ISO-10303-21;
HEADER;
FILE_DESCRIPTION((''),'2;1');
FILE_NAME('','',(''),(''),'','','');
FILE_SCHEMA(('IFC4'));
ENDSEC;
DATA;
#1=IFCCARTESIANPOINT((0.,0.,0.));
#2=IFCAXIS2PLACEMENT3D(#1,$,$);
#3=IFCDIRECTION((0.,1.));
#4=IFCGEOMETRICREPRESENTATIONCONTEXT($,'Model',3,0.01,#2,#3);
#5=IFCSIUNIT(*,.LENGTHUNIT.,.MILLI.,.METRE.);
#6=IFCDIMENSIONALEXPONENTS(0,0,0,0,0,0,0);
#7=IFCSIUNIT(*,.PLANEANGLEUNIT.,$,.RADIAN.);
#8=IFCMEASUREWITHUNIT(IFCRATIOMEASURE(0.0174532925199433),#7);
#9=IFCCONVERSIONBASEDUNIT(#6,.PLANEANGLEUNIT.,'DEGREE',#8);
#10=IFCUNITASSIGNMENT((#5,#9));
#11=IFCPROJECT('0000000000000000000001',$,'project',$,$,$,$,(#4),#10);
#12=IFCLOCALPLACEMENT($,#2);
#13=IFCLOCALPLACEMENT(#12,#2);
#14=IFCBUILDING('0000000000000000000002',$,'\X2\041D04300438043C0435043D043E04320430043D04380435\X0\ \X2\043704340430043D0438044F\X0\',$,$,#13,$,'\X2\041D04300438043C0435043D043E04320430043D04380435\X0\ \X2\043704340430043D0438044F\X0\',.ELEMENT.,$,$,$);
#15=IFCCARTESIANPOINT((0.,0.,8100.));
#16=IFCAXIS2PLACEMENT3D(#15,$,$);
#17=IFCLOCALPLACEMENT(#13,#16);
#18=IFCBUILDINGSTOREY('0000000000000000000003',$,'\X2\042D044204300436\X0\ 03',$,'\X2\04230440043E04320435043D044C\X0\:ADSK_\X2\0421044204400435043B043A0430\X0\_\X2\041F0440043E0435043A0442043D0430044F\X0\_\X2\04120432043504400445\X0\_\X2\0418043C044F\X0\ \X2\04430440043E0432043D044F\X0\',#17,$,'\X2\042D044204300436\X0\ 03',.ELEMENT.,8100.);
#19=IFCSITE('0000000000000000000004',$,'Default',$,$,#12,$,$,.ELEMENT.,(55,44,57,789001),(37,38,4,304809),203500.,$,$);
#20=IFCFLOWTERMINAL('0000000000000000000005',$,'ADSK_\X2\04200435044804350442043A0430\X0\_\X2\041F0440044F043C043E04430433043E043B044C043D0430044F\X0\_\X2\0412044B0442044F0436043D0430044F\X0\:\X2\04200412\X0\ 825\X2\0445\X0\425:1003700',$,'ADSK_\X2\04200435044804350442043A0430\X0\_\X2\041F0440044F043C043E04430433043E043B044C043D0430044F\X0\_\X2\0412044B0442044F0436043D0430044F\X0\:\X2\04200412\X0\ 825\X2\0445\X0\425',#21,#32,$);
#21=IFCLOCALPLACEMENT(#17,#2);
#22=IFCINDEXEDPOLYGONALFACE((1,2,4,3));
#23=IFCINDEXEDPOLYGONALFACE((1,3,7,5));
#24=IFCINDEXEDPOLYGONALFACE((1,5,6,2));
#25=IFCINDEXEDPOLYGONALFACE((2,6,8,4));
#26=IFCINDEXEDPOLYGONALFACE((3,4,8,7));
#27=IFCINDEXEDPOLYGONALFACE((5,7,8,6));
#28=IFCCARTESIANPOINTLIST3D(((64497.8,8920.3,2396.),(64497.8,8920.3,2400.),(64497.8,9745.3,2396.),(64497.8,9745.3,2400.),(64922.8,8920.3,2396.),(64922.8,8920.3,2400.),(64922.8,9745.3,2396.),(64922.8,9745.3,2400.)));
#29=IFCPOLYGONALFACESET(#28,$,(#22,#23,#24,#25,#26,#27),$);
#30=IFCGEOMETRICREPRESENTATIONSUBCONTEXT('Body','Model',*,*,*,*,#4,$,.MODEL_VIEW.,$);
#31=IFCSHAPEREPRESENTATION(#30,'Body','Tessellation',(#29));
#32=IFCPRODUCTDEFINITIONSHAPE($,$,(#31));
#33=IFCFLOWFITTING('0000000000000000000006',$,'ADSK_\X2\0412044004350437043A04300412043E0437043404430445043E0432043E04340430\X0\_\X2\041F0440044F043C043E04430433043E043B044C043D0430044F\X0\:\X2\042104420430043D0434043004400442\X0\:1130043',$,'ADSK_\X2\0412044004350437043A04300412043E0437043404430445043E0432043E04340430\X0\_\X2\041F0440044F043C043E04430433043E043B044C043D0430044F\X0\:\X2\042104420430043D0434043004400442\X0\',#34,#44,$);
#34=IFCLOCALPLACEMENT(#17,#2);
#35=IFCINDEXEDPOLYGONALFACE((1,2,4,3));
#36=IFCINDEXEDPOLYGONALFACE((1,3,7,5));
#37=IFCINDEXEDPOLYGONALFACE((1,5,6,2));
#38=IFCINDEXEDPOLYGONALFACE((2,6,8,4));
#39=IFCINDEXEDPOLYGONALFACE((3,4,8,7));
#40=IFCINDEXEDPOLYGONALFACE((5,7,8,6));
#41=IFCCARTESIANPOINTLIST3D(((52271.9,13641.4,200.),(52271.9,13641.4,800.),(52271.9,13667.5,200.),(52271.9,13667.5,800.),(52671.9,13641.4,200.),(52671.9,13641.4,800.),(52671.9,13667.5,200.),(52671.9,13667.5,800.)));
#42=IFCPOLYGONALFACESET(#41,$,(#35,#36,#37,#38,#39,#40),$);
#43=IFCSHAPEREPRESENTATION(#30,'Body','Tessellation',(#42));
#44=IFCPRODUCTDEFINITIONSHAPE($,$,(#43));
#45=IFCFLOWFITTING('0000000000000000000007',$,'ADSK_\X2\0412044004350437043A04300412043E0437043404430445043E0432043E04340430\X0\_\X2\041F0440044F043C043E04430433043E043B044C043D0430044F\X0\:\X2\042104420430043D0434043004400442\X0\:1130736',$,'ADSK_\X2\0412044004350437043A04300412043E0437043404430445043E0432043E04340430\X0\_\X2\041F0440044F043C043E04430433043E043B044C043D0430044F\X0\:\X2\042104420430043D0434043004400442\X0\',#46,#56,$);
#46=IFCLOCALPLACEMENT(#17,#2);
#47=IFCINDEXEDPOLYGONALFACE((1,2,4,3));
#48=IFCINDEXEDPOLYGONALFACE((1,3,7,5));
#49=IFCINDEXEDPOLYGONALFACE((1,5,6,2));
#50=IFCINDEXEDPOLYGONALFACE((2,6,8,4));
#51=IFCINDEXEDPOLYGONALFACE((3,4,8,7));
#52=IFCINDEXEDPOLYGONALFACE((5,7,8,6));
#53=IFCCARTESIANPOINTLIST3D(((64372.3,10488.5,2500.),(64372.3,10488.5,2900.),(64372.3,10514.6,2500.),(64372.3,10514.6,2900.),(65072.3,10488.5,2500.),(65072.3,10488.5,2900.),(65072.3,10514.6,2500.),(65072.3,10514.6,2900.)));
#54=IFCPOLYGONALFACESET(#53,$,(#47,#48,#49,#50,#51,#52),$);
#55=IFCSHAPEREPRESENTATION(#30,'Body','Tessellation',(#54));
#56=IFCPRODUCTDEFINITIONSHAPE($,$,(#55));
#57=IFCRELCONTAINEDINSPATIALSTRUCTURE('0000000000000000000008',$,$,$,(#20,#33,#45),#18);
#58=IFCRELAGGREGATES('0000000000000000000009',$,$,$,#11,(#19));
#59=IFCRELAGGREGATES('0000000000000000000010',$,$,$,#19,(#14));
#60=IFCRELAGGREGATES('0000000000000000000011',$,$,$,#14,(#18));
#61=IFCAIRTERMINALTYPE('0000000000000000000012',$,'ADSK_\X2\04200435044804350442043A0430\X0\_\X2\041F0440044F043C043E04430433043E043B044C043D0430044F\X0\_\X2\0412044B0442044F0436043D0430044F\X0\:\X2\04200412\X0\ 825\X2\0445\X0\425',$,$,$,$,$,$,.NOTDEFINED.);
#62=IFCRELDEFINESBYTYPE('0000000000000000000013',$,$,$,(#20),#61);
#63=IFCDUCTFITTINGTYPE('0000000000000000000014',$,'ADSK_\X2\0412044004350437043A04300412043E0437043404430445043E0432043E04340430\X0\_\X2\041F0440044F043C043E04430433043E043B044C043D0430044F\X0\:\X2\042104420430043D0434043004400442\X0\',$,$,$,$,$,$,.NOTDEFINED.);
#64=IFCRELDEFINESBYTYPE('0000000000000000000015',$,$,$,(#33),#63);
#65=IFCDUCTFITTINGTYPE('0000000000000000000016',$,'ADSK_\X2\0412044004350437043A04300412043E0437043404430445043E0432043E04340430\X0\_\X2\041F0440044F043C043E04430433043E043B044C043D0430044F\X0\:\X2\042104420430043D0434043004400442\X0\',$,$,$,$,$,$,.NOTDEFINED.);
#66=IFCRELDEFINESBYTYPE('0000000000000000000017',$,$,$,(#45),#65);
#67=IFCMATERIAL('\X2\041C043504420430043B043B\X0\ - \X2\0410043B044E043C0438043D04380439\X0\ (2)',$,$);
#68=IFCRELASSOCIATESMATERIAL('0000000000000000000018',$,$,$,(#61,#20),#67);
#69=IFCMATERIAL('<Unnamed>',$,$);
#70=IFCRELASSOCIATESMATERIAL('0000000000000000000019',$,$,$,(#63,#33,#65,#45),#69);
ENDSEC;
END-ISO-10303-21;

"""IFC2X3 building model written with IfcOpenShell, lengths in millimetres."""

from ifc_helpers import new_model, entity, si_unit, converted_unit, direction, frame, frame_2d, origin, origin_2d_with_axis, place, context, subcontext, project, spatial, rectangle, extrude, source, transform, mapped, material, type_object, type_shapes, element, save


model = new_model("IFC2X3")

# Units and contexts
model_context = context("Model", 3, precision=0.01, world=origin(), true_north=direction((0.0, 1.0)))
body_context = subcontext(model_context, "Body", "Model", "MODEL_VIEW")
ifc_project = project(units=[si_unit("LENGTHUNIT", "METRE", prefix="MILLI"), converted_unit("PLANEANGLEUNIT", "DEGREE", entity("IfcRatioMeasure", 0.0174532925199433), si_unit("PLANEANGLEUNIT", "RADIAN"), dimensions=[0, 0, 0, 0, 0, 0, 0])], contexts=[model_context])

# Site, building, storey
site_placement = place(None, frame((0.0, 0.0, 0.0)))
site = spatial("IfcSite", under=ifc_project, at=site_placement, Name="Default", CompositionType="ELEMENT", RefLatitude=(55, 44, 57, 789001), RefLongitude=(37, 38, 4, 304809), RefElevation=203500.0)
building_placement = place(site_placement, origin())
building = spatial("IfcBuilding", under=site, at=building_placement, Name="Наименование здания", LongName="Наименование здания", CompositionType="ELEMENT")
storey_placement = place(building_placement, frame((0.0, 0.0, 8100.0)))
storey = spatial("IfcBuildingStorey", under=building, at=storey_placement, Name="Этаж 03", ObjectType="Уровень:ADSK_Стрелка_Проектная_Вверх_Имя уровня", LongName="Этаж 03", CompositionType="ELEMENT", Elevation=8100.0)

# Shared definitions
ifc_material_1 = material(Name="<Unnamed>")

# Flow terminal
ifc_material_2 = material(Name="Металл - Алюминий (2)")
air_terminal_type = type_object("IfcAirTerminalType", Name="ADSK_Решетка_Прямоугольная_Вытяжная:РВ 825х425", PredefinedType="NOTDEFINED", material=ifc_material_2)
shared_shape_1 = source(origin(), body_context, "Body", "SweptSolid", [
    extrude(rectangle(XDim=4.0, YDim=825.0, at=origin_2d_with_axis()), frame((0.0, -2.0, -212.5), z_axis=(0.0, 0.0, 1.0), x_axis=(0.0, 1.0, 0.0)), (0.0, 0.0, 1.0), 425.0),
])
type_shapes(air_terminal_type, [shared_shape_1])
flow_terminal_placement = place(storey_placement, frame((64710.3, 9332.8, 2400.0), z_axis=(1.0, 0.0, 0.0), x_axis=(0.0, 1.0, 0.0)))
element("IfcFlowTerminal", 1, at=flow_terminal_placement, inside=storey, type_object=air_terminal_type, material=ifc_material_2, Name="ADSK_Решетка_Прямоугольная_Вытяжная:РВ 825х425:1003700", ObjectType="ADSK_Решетка_Прямоугольная_Вытяжная:РВ 825х425", context=body_context, shape_type="MappedRepresentation", body=[
    mapped(shared_shape_1, transform((0.0, 0.0, 0.0), scale=1.0)),
])

# Flow fittings
duct_fitting_type_1 = type_object("IfcDuctFittingType", Name="ADSK_ВрезкаВоздуховода_Прямоугольная:Стандарт", PredefinedType="NOTDEFINED", material=ifc_material_1)
shared_shape_2 = source(origin(), body_context, "Body", "SweptSolid", [
    extrude(rectangle(XDim=600.0, YDim=26.1, at=origin_2d_with_axis()), frame((7.0, 0.0, -200.0), z_axis=(0.0, 0.0, 1.0), x_axis=(0.0, -1.0, 0.0)), (0.0, 0.0, 1.0), 400.0),
])
type_shapes(duct_fitting_type_1, [shared_shape_2])
flow_fitting_1_placement = place(storey_placement, frame((52471.9, 13647.5, 500.0), z_axis=(1.0, 0.0, 0.0), x_axis=(0.0, 1.0, 0.0)))
element("IfcFlowFitting", 2, at=flow_fitting_1_placement, inside=storey, type_object=duct_fitting_type_1, material=ifc_material_1, Name="ADSK_ВрезкаВоздуховода_Прямоугольная:Стандарт:1130043", ObjectType="ADSK_ВрезкаВоздуховода_Прямоугольная:Стандарт", context=body_context, shape_type="MappedRepresentation", body=[
    mapped(shared_shape_2, transform((0.0, 0.0, 0.0), scale=1.0)),
])
duct_fitting_type_2 = type_object("IfcDuctFittingType", Name="ADSK_ВрезкаВоздуховода_Прямоугольная:Стандарт", PredefinedType="NOTDEFINED", material=ifc_material_1)
shared_shape_3 = source(origin(), body_context, "Body", "SweptSolid", [
    extrude(rectangle(XDim=26.1, YDim=700.0, at=frame_2d((0.0, 0.0), x_axis=(1.0, 0.0))), frame((7.0, 0.0, -200.0)), (0.0, 0.0, 1.0), 400.0),
])
type_shapes(duct_fitting_type_2, [shared_shape_3])
flow_fitting_2_placement = place(storey_placement, frame((64722.3, 10508.5, 2700.0), z_axis=(0.0, 0.0, -1.0), x_axis=(0.0, -1.0, 0.0)))
element("IfcFlowFitting", 3, at=flow_fitting_2_placement, inside=storey, type_object=duct_fitting_type_2, material=ifc_material_1, Name="ADSK_ВрезкаВоздуховода_Прямоугольная:Стандарт:1130736", ObjectType="ADSK_ВрезкаВоздуховода_Прямоугольная:Стандарт", context=body_context, shape_type="MappedRepresentation", body=[
    mapped(shared_shape_3, transform((0.0, 0.0, 0.0), scale=1.0)),
])

save(model, "model.ifc")
